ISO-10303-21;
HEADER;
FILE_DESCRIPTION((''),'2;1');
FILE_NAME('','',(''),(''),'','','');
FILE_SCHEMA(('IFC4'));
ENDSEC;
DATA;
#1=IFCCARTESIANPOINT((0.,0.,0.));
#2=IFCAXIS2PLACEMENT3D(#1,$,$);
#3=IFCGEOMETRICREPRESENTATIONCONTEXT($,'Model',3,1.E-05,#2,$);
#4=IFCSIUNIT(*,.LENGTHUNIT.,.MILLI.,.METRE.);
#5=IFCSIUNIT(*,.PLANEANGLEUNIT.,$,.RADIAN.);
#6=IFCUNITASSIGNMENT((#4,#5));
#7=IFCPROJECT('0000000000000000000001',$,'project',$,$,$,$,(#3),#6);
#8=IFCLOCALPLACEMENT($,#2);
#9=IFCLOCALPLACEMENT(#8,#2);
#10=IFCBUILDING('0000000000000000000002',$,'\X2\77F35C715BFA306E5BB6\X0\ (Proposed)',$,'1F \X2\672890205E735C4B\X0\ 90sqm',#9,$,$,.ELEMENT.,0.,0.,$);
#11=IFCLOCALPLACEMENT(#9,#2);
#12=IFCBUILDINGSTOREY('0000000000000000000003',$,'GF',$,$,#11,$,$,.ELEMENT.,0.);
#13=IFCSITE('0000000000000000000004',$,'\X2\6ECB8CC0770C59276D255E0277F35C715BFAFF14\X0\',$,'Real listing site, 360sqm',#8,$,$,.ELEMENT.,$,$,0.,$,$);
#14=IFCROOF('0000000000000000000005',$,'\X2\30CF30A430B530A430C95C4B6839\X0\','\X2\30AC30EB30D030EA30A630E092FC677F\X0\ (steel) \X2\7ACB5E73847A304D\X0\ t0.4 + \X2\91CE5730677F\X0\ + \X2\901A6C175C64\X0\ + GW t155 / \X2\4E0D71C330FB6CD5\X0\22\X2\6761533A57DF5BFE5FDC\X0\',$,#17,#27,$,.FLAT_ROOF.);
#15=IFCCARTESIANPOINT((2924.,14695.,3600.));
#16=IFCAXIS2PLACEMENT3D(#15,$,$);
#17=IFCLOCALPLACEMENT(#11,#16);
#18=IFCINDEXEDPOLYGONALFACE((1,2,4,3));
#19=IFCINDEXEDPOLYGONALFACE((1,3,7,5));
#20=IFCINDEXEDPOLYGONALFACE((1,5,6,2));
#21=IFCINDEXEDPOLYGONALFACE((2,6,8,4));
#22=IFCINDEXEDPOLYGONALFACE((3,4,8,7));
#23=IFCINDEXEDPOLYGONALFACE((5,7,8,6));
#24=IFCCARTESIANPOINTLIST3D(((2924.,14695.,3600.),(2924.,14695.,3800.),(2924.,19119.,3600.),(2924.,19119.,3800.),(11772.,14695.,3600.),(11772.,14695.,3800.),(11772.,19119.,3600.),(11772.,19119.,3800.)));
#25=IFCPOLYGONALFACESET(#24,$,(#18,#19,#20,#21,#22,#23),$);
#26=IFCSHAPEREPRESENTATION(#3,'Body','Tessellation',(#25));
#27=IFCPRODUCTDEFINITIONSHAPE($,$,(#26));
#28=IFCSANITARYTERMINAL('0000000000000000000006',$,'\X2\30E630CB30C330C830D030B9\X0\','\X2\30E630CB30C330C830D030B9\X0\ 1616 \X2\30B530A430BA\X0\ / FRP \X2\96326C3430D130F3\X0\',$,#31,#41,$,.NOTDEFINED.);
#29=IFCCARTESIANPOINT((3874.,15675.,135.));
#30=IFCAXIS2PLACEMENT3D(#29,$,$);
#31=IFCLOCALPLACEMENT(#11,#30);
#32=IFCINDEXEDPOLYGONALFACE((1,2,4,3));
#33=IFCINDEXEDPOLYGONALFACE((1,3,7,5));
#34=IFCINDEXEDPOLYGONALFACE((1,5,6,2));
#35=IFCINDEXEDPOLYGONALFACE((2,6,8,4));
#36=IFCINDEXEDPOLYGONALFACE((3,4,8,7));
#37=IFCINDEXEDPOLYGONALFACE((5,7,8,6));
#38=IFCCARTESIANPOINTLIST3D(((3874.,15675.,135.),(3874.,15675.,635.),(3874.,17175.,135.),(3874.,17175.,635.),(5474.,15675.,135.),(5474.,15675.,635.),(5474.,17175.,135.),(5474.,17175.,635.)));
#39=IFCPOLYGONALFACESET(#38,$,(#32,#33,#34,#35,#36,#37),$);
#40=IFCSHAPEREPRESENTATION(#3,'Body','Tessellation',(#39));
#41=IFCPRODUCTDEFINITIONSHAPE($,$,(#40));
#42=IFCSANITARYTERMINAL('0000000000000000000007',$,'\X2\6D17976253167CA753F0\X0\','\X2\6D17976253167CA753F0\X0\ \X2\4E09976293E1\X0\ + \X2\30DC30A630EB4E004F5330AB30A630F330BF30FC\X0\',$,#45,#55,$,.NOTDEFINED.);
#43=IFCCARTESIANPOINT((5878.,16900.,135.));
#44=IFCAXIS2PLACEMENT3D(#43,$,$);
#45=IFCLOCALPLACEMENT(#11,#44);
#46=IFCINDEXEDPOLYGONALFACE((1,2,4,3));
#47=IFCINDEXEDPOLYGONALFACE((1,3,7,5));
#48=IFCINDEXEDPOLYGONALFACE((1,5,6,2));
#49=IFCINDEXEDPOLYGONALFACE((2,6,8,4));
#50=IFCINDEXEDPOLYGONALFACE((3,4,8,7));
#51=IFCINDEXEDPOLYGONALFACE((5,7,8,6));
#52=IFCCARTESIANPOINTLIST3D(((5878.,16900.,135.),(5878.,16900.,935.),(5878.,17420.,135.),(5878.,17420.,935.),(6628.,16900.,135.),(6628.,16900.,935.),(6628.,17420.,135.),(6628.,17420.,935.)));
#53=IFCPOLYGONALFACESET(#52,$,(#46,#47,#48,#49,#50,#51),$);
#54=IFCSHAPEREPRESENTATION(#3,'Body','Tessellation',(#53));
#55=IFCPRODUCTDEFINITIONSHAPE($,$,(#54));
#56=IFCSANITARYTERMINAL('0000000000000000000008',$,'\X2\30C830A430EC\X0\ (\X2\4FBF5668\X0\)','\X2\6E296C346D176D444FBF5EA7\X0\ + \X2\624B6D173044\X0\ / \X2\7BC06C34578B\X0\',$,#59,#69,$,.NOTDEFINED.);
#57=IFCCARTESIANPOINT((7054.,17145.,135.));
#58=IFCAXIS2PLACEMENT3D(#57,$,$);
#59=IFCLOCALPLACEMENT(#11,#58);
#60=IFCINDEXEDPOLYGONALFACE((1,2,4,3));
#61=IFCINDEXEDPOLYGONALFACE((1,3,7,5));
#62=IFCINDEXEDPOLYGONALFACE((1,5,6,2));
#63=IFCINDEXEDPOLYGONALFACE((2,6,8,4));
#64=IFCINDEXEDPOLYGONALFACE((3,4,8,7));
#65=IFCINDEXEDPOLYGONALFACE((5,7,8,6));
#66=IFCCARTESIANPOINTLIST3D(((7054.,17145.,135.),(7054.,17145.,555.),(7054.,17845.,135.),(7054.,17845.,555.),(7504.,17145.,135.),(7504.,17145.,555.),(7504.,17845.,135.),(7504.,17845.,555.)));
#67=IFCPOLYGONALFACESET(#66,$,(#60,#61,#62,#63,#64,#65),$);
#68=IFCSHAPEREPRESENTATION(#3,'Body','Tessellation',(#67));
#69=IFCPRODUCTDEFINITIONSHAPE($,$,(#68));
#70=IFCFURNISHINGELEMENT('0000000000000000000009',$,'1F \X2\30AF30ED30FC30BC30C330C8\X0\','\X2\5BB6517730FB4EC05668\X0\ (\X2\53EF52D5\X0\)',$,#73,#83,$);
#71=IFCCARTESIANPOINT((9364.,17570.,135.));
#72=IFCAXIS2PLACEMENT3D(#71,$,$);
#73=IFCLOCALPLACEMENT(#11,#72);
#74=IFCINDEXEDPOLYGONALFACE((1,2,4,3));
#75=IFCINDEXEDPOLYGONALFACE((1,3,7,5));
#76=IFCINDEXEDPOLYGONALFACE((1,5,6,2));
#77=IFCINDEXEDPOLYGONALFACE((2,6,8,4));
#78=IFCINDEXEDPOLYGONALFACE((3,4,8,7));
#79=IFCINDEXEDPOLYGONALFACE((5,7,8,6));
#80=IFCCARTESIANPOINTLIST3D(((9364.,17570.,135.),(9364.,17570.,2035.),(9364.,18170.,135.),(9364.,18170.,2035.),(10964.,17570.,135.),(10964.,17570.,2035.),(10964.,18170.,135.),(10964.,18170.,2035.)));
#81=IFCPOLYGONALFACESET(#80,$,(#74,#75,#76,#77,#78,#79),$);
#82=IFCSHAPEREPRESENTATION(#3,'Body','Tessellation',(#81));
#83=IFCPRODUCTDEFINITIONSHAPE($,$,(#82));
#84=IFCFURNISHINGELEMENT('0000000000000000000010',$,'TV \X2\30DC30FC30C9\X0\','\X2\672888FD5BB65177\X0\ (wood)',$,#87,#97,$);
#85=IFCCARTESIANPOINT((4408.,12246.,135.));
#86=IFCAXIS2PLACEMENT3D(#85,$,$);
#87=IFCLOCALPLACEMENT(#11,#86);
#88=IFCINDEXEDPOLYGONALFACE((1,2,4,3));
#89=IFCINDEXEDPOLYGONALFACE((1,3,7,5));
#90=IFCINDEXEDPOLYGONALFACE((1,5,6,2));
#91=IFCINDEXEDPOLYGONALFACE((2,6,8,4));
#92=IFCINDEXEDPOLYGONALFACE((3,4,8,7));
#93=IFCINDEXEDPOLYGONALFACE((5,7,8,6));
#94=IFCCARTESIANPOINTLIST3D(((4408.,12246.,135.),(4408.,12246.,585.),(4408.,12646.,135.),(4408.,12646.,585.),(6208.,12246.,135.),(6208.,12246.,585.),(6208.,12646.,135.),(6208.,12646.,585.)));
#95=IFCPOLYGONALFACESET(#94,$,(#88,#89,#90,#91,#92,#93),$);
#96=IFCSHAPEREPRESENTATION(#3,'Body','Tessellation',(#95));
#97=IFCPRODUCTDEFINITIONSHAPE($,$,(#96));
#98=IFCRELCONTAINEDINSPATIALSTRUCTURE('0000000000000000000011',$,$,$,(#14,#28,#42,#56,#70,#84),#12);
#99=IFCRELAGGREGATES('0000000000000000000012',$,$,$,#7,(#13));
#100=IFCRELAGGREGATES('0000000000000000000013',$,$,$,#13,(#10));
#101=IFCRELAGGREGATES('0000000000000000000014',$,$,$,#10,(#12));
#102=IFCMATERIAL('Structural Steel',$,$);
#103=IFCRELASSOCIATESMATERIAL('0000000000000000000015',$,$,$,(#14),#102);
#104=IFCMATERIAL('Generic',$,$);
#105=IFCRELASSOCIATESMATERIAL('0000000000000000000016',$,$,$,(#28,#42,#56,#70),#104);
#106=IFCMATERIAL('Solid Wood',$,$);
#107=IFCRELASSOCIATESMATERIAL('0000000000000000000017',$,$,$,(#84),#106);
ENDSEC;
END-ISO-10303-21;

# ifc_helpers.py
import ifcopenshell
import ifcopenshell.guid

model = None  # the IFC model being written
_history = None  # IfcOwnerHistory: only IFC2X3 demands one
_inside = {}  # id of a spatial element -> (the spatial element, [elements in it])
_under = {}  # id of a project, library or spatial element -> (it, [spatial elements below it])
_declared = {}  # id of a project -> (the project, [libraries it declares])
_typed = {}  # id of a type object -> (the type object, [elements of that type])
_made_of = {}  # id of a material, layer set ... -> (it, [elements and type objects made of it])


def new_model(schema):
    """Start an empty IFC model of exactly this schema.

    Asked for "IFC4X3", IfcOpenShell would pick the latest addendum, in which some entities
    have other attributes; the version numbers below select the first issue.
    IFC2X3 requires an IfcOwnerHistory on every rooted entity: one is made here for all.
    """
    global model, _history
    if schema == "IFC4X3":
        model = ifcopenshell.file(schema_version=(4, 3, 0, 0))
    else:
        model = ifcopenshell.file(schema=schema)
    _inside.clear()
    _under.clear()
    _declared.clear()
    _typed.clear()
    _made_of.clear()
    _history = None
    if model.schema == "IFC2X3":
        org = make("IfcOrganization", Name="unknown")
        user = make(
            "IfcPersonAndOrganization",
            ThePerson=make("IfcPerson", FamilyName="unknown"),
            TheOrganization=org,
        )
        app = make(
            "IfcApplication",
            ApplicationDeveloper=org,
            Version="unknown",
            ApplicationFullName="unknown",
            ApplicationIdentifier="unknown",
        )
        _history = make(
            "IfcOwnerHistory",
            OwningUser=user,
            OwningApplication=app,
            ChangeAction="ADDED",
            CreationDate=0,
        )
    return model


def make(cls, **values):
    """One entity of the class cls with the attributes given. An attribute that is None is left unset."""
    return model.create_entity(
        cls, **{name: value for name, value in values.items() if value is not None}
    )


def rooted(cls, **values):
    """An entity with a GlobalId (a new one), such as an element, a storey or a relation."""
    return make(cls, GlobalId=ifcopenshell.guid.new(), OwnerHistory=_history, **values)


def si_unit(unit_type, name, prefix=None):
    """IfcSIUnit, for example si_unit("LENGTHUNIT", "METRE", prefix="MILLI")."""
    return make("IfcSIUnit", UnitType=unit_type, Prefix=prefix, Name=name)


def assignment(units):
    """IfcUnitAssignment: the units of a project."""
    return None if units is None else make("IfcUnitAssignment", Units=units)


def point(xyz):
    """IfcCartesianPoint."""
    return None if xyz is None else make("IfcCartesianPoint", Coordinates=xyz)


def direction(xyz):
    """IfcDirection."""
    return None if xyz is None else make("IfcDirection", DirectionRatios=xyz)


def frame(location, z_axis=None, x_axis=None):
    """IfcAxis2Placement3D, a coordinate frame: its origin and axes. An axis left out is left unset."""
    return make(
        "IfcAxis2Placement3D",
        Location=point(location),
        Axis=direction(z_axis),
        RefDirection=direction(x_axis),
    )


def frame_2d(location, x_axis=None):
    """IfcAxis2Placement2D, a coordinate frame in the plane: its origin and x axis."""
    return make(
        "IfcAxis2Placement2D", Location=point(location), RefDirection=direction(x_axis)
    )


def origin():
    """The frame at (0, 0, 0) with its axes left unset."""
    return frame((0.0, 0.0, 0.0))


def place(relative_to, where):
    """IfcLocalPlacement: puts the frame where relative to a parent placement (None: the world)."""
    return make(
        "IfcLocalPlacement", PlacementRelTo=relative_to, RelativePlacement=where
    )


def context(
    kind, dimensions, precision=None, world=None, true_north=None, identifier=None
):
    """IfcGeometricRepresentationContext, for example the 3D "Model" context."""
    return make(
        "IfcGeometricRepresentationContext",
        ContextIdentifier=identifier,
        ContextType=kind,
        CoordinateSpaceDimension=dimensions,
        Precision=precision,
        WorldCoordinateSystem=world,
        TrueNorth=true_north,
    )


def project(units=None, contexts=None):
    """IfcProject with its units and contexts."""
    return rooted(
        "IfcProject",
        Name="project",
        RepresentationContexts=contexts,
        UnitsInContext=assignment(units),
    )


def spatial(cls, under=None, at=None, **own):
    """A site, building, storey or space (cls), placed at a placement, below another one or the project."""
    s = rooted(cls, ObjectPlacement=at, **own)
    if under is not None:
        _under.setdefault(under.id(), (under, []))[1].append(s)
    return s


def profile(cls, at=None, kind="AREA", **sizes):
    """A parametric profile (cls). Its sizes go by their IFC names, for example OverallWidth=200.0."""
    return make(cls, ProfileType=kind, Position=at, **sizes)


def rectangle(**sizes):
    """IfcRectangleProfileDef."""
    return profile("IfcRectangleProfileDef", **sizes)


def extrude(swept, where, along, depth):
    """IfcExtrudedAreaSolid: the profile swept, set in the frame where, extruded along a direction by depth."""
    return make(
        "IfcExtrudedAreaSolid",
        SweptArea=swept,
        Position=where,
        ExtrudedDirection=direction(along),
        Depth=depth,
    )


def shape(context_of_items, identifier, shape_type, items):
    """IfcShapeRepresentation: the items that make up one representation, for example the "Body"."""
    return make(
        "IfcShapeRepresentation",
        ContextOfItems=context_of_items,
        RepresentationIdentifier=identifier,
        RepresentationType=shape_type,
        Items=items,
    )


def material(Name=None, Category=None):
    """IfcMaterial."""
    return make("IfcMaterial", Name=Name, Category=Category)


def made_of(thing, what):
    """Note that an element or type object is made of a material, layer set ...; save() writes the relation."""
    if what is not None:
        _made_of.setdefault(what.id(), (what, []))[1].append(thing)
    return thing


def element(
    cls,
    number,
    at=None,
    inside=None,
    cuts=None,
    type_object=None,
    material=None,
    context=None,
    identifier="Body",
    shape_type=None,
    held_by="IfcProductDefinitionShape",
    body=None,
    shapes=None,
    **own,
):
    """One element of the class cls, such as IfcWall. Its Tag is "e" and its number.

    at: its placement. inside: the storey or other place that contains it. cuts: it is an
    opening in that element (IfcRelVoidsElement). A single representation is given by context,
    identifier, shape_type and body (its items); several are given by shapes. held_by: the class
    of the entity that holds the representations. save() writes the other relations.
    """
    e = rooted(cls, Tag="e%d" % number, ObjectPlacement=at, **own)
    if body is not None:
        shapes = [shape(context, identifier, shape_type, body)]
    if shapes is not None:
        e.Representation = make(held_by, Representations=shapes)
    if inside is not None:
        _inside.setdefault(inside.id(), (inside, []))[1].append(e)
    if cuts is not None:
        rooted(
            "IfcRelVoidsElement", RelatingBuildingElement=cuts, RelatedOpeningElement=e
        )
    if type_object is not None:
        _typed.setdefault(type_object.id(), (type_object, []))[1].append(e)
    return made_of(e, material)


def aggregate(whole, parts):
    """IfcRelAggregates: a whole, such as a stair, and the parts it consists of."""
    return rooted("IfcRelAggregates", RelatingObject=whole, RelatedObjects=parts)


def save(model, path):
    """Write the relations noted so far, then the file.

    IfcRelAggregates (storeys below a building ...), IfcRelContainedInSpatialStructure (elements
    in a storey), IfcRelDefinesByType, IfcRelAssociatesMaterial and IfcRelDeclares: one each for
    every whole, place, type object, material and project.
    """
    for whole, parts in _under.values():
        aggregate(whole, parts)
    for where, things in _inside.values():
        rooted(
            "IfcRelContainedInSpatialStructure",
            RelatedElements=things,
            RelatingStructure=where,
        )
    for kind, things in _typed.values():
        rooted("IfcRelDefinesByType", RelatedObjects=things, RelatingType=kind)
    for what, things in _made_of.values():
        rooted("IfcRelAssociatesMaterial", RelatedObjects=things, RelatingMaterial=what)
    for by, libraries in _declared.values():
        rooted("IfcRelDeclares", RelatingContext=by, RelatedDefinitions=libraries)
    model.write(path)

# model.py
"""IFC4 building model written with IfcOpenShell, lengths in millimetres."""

from ifc_helpers import new_model, si_unit, frame, frame_2d, origin, place, context, project, spatial, rectangle, extrude, material, element, save


model = new_model("IFC4")

# Units and contexts
model_context = context("Model", 3, precision=1e-05, world=origin())
ifc_project = project(units=[si_unit("LENGTHUNIT", "METRE", prefix="MILLI"), si_unit("PLANEANGLEUNIT", "RADIAN")], contexts=[model_context])

# Site, building, storey
site_placement = place(None, origin())
site = spatial("IfcSite", under=ifc_project, at=site_placement, Name="滋賀県大津市石山寺４", ObjectType="Real listing site, 360sqm", CompositionType="ELEMENT", RefElevation=0.0)
building_placement = place(site_placement, origin())
building = spatial("IfcBuilding", under=site, at=building_placement, Name="石山寺の家 (Proposed)", ObjectType="1F 木造平屋 90sqm", CompositionType="ELEMENT", ElevationOfRefHeight=0.0, ElevationOfTerrain=0.0)
storey_placement = place(building_placement, origin())
storey = spatial("IfcBuildingStorey", under=building, at=storey_placement, Name="GF", CompositionType="ELEMENT", Elevation=0.0)

# Shared definitions
ifc_material_1 = material(Name="Solid Wood")

# Roof
ifc_material_2 = material(Name="Structural Steel")
roof_placement = place(storey_placement, frame((2924.0, 14695.0, 3600.0)))
element("IfcRoof", 1, at=roof_placement, inside=storey, material=ifc_material_2, Name="ハイサイド屋根", Description="ガルバリウム鋼板 (steel) 立平葺き t0.4 + 野地板 + 通気層 + GW t155 / 不燃・法22条区域対応", PredefinedType="FLAT_ROOF", context=model_context, shape_type="SweptSolid", body=[
    extrude(rectangle(XDim=8848.0, YDim=4424.0, at=frame_2d((4424.0, 2212.0))), frame((2924.0, 14695.0, 3600.0)), (0.0, 0.0, 1.0), 200.0),
])

# Sanitary terminals
ifc_material_3 = material(Name="Generic")
sanitary_terminal_1_placement = place(storey_placement, frame((3874.0, 15675.0, 135.0)))
element("IfcSanitaryTerminal", 2, at=sanitary_terminal_1_placement, inside=storey, material=ifc_material_3, Name="ユニットバス", Description="ユニットバス 1616 サイズ / FRP 防水パン", PredefinedType="NOTDEFINED", context=model_context, shape_type="SweptSolid", body=[
    extrude(rectangle(XDim=1600.0, YDim=1500.0, at=frame_2d((800.0, 750.0))), frame((3874.0, 15675.0, 135.0)), (0.0, 0.0, 1.0), 500.0),
])
sanitary_terminal_2_placement = place(storey_placement, frame((5878.0, 16900.0, 135.0)))
element("IfcSanitaryTerminal", 3, at=sanitary_terminal_2_placement, inside=storey, material=ifc_material_3, Name="洗面化粧台", Description="洗面化粧台 三面鏡 + ボウル一体カウンター", PredefinedType="NOTDEFINED", context=model_context, shape_type="SweptSolid", body=[
    extrude(rectangle(XDim=750.0, YDim=520.0, at=frame_2d((375.0, 260.0))), frame((5878.0, 16900.0, 135.0)), (0.0, 0.0, 1.0), 800.0),
])
sanitary_terminal_3_placement = place(storey_placement, frame((7054.0, 17145.0, 135.0)))
element("IfcSanitaryTerminal", 4, at=sanitary_terminal_3_placement, inside=storey, material=ifc_material_3, Name="トイレ (便器)", Description="温水洗浄便座 + 手洗い / 節水型", PredefinedType="NOTDEFINED", context=model_context, shape_type="SweptSolid", body=[
    extrude(rectangle(XDim=450.0, YDim=700.0, at=frame_2d((225.0, 350.0))), frame((7054.0, 17145.0, 135.0)), (0.0, 0.0, 1.0), 420.0),
])

# Furnishing elements
furnishing_1_placement = place(storey_placement, frame((9364.0, 17570.0, 135.0)))
element("IfcFurnishingElement", 5, at=furnishing_1_placement, inside=storey, material=ifc_material_3, Name="1F クローゼット", Description="家具・什器 (可動)", context=model_context, shape_type="SweptSolid", body=[
    extrude(rectangle(XDim=1600.0, YDim=600.0, at=frame_2d((800.0, 300.0))), frame((9364.0, 17570.0, 135.0)), (0.0, 0.0, 1.0), 1900.0),
])
furnishing_2_placement = place(storey_placement, frame((4408.0, 12246.0, 135.0)))
element("IfcFurnishingElement", 6, at=furnishing_2_placement, inside=storey, material=ifc_material_1, Name="TV ボード", Description="木製家具 (wood)", context=model_context, shape_type="SweptSolid", body=[
    extrude(rectangle(XDim=1800.0, YDim=400.0, at=frame_2d((900.0, 200.0))), frame((4408.0, 12246.0, 135.0)), (0.0, 0.0, 1.0), 450.0),
])

save(model, "model.ifc")
